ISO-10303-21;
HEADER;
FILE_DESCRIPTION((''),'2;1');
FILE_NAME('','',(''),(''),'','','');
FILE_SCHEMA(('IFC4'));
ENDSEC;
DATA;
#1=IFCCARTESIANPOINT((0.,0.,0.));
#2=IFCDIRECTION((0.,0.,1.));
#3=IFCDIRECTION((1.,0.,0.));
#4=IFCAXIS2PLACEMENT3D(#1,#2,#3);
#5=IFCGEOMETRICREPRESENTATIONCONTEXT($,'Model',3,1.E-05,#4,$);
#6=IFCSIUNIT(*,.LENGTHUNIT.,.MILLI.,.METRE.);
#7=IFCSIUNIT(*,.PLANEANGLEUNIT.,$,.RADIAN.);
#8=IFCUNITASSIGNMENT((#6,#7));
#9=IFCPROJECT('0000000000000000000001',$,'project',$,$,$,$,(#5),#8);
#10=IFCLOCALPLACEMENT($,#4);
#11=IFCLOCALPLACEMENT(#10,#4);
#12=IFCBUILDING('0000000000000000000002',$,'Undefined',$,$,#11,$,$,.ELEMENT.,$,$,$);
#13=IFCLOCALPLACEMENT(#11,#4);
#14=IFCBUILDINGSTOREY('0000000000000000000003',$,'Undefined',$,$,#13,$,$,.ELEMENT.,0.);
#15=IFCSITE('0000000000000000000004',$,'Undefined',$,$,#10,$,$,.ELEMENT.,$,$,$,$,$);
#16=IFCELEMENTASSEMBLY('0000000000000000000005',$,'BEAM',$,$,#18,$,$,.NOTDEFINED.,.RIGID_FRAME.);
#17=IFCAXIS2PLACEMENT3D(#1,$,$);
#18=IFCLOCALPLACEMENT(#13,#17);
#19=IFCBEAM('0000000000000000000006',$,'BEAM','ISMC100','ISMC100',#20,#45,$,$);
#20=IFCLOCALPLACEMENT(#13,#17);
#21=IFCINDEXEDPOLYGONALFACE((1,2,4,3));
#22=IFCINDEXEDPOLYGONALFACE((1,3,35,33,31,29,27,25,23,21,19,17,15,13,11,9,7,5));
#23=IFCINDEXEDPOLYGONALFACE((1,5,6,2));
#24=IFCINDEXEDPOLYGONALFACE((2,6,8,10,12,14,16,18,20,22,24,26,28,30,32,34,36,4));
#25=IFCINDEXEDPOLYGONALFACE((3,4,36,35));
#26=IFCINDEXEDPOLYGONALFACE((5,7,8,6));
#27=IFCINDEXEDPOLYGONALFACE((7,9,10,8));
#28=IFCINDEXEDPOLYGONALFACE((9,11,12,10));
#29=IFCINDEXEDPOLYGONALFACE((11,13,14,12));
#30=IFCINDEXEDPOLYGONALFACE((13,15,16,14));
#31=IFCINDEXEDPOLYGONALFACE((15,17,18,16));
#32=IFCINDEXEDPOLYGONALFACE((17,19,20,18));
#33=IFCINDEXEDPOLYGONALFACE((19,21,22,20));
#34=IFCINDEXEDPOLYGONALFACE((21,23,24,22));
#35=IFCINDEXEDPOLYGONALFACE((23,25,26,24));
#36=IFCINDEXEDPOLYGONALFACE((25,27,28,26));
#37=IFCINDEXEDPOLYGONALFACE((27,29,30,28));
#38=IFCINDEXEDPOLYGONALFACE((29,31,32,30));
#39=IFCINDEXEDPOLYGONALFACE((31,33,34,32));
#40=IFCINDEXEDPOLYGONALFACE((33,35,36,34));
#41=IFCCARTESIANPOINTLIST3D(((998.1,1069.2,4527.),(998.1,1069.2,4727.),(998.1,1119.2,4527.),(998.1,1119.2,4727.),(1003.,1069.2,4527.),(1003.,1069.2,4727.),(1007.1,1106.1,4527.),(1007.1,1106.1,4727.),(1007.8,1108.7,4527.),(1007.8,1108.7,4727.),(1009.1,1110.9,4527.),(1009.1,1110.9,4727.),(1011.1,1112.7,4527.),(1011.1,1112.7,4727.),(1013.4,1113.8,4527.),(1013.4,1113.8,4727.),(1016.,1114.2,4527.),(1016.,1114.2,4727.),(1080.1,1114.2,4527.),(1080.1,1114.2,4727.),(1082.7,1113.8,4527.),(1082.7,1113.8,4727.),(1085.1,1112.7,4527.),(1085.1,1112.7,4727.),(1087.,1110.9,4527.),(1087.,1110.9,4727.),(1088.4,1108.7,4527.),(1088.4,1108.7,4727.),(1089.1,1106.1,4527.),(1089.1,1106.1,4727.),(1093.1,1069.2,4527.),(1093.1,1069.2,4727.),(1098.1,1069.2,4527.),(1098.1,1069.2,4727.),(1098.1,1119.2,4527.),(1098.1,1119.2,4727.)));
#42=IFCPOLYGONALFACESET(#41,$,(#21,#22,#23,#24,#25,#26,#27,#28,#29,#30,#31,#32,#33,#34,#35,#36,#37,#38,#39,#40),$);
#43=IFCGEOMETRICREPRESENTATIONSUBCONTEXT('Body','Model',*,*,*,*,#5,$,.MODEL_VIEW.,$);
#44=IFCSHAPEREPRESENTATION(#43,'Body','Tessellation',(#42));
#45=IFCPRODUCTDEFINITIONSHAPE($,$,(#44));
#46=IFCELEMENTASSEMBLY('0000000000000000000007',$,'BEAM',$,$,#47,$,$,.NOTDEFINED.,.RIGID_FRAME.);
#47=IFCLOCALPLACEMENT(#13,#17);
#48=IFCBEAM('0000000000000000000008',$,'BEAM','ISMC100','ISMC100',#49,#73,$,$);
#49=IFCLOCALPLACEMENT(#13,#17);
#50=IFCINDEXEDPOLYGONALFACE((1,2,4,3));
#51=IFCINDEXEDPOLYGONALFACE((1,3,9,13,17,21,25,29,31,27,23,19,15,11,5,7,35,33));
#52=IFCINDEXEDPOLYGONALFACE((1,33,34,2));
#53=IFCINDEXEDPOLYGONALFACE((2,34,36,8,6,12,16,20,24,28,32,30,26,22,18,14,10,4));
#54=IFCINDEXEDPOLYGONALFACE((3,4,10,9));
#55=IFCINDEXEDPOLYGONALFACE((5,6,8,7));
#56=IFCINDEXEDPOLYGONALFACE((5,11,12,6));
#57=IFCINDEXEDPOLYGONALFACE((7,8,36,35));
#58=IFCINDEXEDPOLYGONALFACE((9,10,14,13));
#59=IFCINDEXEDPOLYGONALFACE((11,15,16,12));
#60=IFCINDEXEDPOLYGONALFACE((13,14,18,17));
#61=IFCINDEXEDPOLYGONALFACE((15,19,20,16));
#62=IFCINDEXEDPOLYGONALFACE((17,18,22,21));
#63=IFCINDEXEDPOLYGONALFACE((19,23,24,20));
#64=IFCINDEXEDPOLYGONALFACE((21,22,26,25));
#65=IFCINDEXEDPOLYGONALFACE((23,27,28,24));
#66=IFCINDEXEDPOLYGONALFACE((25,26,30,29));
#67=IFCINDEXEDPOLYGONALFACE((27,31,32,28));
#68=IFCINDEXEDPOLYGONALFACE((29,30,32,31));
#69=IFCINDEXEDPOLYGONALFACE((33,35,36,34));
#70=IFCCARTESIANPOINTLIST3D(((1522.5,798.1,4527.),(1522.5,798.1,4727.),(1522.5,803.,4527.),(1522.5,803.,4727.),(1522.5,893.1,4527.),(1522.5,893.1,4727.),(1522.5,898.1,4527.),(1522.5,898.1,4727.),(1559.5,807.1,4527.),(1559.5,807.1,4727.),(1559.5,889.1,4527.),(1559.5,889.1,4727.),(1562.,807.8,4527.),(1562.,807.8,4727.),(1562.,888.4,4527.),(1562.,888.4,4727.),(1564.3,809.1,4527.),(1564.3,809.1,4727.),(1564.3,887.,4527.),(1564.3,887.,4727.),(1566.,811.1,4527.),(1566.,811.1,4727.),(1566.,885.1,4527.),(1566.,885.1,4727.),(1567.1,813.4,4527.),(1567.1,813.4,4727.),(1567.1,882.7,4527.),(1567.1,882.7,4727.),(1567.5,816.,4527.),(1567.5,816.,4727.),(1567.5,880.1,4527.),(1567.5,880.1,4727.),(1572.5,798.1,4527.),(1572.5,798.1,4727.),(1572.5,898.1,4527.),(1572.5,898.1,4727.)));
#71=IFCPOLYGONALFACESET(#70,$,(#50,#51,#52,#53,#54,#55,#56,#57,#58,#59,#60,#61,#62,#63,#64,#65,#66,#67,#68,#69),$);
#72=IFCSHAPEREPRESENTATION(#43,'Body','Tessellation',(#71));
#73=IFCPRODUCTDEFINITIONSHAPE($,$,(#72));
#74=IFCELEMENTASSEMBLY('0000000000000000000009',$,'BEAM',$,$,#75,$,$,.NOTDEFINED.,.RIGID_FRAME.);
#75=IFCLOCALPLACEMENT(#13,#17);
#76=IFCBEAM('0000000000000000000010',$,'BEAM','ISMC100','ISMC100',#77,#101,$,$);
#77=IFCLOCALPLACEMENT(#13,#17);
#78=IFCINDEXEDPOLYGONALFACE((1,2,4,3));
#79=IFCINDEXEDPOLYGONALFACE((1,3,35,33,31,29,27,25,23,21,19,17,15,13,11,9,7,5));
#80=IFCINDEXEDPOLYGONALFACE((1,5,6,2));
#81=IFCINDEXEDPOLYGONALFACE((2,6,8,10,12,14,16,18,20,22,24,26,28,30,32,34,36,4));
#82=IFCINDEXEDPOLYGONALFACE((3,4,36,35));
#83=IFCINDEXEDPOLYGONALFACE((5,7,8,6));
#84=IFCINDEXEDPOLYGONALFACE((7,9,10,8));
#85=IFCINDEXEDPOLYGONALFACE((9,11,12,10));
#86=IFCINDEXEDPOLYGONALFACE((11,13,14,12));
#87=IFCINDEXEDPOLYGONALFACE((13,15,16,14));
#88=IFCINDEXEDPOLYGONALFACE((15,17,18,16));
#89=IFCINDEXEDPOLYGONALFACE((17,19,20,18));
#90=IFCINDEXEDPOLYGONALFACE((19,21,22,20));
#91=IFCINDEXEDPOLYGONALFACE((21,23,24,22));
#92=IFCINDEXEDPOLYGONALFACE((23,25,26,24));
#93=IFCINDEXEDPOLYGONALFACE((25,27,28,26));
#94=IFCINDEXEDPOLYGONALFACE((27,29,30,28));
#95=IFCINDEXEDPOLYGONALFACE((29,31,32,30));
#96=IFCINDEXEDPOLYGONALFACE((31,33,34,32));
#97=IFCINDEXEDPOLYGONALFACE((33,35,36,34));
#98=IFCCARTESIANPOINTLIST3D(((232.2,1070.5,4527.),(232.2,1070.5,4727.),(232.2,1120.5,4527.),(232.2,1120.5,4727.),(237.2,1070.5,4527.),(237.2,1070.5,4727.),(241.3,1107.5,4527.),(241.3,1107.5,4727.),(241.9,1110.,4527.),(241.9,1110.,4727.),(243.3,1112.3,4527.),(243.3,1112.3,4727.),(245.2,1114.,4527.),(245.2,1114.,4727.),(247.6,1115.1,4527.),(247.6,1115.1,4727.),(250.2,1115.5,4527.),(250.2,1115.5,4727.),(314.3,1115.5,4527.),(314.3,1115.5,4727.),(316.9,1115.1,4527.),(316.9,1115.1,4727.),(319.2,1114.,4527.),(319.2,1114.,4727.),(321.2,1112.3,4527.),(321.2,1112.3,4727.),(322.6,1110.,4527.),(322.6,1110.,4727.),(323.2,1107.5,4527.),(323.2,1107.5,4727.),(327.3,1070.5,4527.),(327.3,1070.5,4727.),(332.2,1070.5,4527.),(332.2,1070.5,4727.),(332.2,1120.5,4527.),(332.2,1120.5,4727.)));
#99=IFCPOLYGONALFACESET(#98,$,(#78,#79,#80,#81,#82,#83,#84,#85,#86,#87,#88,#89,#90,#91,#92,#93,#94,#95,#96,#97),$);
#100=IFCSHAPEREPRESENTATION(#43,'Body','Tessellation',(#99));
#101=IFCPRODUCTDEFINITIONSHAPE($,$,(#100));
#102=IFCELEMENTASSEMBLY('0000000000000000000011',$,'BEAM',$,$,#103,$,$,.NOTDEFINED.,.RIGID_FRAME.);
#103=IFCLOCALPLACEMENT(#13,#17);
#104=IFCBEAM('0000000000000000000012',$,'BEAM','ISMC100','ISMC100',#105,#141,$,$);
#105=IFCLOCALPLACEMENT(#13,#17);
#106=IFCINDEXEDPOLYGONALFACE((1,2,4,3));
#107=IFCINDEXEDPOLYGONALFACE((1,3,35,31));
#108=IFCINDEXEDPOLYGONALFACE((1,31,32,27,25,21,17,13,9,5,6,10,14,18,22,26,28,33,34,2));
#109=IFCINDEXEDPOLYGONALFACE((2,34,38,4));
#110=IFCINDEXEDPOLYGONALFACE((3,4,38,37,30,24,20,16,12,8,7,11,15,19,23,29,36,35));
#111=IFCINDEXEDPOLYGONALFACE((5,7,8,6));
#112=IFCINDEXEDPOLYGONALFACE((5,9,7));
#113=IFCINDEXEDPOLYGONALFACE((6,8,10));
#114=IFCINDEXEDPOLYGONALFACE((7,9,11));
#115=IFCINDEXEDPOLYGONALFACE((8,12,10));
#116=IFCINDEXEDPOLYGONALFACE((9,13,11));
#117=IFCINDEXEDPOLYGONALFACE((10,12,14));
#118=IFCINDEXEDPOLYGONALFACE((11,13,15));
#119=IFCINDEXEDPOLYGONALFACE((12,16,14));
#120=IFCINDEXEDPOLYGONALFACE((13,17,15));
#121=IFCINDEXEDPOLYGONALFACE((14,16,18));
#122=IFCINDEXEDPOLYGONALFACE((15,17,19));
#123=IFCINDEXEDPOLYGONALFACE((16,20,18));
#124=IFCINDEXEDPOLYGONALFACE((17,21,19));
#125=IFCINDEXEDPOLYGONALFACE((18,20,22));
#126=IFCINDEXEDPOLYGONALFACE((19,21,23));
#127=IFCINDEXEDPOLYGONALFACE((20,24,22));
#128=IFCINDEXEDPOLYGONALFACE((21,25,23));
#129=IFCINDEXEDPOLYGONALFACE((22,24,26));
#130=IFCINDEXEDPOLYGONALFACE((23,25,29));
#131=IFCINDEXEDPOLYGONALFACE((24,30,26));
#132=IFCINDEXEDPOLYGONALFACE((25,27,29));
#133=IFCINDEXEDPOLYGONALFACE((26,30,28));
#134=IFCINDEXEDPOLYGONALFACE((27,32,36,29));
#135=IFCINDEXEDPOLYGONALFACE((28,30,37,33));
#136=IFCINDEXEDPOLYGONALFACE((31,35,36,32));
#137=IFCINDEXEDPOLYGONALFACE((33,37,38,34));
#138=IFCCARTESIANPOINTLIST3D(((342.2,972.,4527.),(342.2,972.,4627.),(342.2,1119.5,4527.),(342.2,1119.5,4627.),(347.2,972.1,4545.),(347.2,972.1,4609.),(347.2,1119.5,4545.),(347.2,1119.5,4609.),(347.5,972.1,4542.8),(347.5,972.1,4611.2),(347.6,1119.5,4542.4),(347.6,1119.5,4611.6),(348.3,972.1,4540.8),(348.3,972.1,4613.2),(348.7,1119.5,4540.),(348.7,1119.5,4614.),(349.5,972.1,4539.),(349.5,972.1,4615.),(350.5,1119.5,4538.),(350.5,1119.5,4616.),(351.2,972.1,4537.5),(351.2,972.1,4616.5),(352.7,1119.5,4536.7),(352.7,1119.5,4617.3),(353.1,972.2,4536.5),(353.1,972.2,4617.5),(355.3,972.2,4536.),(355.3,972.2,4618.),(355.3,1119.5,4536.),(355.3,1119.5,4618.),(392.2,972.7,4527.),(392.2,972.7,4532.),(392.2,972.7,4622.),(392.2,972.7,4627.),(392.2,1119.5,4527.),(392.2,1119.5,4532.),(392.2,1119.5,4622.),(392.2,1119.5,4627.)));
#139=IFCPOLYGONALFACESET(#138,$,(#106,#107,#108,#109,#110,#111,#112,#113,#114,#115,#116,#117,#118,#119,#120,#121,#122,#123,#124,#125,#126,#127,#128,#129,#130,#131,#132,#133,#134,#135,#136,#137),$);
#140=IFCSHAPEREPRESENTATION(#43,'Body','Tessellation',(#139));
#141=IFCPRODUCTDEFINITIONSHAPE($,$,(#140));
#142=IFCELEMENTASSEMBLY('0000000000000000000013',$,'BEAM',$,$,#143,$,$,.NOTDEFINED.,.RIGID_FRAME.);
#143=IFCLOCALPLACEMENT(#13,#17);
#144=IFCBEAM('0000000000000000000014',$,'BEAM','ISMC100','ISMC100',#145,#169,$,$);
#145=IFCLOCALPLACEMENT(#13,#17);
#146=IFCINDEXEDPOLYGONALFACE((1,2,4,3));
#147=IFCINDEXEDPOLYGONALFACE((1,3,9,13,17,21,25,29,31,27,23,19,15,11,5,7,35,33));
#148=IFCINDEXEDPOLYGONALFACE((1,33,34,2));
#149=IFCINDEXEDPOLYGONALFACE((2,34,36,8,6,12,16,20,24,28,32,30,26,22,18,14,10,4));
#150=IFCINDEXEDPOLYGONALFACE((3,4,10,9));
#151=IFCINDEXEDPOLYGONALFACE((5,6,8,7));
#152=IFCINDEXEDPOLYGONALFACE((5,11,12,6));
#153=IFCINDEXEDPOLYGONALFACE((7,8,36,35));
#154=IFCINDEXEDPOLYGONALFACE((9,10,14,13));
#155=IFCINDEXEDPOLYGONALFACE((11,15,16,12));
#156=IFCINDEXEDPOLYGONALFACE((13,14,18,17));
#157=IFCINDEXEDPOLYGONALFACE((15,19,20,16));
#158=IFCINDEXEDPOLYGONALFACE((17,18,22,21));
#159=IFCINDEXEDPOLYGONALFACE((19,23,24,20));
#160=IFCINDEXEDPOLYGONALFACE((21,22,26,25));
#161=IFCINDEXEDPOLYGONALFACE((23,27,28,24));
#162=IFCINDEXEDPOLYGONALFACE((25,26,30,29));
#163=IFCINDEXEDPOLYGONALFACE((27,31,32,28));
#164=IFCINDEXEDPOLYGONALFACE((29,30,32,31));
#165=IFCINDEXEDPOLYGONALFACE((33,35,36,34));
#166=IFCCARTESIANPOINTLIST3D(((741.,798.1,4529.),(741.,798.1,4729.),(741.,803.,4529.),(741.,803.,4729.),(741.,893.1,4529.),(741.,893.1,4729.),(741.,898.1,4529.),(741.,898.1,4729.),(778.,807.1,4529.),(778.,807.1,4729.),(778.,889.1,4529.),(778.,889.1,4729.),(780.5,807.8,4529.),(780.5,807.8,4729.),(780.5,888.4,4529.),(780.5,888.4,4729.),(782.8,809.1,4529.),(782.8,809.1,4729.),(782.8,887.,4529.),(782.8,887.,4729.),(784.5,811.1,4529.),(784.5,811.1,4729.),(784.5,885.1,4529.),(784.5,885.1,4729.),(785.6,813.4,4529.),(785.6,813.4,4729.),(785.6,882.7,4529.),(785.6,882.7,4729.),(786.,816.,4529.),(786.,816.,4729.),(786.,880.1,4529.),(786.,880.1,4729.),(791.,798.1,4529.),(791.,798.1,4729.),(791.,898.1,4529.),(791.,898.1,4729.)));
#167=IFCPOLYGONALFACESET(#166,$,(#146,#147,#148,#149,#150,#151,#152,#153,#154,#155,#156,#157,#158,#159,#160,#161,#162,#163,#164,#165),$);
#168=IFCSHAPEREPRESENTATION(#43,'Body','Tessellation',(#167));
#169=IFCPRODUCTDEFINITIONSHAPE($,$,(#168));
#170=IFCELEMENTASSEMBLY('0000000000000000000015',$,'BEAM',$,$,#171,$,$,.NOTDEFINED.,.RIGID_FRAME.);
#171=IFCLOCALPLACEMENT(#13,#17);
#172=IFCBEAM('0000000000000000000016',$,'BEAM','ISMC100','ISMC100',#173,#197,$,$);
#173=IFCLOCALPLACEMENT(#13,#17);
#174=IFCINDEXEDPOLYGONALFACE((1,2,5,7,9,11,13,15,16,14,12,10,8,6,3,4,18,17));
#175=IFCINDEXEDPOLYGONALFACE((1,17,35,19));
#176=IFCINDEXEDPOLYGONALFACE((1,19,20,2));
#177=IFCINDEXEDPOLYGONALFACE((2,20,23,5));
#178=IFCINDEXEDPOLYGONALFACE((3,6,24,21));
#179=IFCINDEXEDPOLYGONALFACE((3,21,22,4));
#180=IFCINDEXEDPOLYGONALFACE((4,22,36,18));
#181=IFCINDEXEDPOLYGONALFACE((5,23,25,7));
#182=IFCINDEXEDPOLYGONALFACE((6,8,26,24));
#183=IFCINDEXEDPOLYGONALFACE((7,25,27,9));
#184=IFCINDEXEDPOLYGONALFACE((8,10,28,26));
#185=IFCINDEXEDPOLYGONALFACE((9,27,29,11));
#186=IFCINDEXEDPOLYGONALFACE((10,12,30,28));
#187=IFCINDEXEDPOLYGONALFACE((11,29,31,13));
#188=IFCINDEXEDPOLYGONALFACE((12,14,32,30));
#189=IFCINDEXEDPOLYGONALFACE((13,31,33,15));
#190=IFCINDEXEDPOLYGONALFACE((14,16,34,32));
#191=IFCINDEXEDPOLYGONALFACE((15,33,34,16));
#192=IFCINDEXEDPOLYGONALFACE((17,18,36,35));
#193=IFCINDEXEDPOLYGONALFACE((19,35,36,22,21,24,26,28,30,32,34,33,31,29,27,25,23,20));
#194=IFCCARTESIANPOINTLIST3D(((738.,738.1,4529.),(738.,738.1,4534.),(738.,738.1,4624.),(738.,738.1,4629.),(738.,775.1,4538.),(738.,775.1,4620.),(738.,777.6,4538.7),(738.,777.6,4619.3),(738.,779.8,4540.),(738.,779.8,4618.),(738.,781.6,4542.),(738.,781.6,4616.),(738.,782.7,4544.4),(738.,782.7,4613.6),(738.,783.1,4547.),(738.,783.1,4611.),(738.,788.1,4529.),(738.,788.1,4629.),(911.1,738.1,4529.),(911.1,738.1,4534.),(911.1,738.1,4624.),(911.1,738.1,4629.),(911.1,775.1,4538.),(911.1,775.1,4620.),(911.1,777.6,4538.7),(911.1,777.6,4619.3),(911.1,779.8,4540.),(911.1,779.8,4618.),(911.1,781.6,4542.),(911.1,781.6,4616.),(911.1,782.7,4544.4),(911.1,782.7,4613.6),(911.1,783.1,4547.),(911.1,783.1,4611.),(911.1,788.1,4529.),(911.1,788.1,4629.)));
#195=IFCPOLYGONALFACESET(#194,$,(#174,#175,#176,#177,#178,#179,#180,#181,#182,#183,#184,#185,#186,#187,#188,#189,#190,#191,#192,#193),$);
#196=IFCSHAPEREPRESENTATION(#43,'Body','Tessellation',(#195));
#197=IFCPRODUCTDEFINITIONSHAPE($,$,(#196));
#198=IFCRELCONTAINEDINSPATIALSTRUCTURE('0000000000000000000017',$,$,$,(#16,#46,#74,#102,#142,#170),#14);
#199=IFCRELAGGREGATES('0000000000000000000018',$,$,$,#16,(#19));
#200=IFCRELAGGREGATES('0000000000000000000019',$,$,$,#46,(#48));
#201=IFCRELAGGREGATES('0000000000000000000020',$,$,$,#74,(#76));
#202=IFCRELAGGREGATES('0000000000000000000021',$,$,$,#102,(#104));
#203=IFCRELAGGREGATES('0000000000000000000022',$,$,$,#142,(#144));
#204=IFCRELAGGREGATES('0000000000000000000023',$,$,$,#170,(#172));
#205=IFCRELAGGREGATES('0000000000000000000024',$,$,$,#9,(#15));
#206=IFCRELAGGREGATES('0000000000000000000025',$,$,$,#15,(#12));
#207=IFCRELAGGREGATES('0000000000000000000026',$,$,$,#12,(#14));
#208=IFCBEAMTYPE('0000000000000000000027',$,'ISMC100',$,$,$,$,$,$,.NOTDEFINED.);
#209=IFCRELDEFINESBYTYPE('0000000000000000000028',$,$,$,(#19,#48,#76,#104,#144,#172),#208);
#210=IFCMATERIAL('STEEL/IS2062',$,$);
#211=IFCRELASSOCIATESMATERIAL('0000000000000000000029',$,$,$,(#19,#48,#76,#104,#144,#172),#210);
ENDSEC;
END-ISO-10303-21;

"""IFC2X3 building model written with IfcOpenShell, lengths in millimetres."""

from ifc_helpers import new_model, si_unit, frame, origin_with_axes, origin_2d_with_axis, place, context, subcontext, project, spatial, u_section, extrude, clip, halfspace, material, type_object, element, aggregate, save


model = new_model("IFC2X3")

# Units and contexts
model_context = context("Model", 3, precision=1e-05, world=origin_with_axes())
body_context = subcontext(model_context, "Body", "Model", "MODEL_VIEW")
ifc_project = project(units=[si_unit("LENGTHUNIT", "METRE", prefix="MILLI"), si_unit("PLANEANGLEUNIT", "RADIAN")], contexts=[model_context])

# Site, building, storey
site_placement = place(None, origin_with_axes())
site = spatial("IfcSite", under=ifc_project, at=site_placement, Name="Undefined", CompositionType="ELEMENT")
building_placement = place(site_placement, origin_with_axes())
building = spatial("IfcBuilding", under=site, at=building_placement, Name="Undefined", CompositionType="ELEMENT")
storey_placement = place(building_placement, origin_with_axes())
storey = spatial("IfcBuildingStorey", under=building, at=storey_placement, Name="Undefined", CompositionType="ELEMENT", Elevation=0.0)

# Shared definitions
ifc_material = material(Name="STEEL/IS2062")

# Element assemblies, beams
beam_type_1 = type_object("IfcBeamType", Name="ISMC100", PredefinedType="NOTDEFINED")
assembly_1_placement = place(storey_placement, origin_with_axes())
assembly_1 = element("IfcElementAssembly", 1, at=assembly_1_placement, inside=storey, Name="BEAM", AssemblyPlace="NOTDEFINED", PredefinedType="RIGID_FRAME")
beam_1_placement = place(assembly_1_placement, frame((1048.1, 1094.2, 4727.0), z_axis=(1.0, 0.0, 0.0), x_axis=(0.0, 0.0, -1.0)))
beam_1 = element("IfcBeam", 2, at=beam_1_placement, type_object=beam_type_1, material=ifc_material, Name="BEAM", Description="ISMC100", ObjectType="ISMC100", context=body_context, shape_type="SweptSolid", body=[
    extrude(u_section(Depth=100.0, FlangeWidth=50.0, WebThickness=5.0, FlangeThickness=7.7, FilletRadius=9.0, FlangeSlope=0.10956, at=origin_2d_with_axis()), frame((200.0, 0.0, 0.0), z_axis=(-1.0, 0.0, 0.0), x_axis=(0.0, -1.0, 0.0)), (0.0, 0.0, 1.0), 200.0),
])
aggregate(assembly_1, [beam_1])
assembly_2_placement = place(storey_placement, origin_with_axes())
assembly_2 = element("IfcElementAssembly", 3, at=assembly_2_placement, inside=storey, Name="BEAM", AssemblyPlace="NOTDEFINED", PredefinedType="RIGID_FRAME")
beam_2_placement = place(assembly_2_placement, frame((1547.5, 848.1, 4727.0), z_axis=(0.0, -1.0, 0.0), x_axis=(0.0, 0.0, -1.0)))
beam_2 = element("IfcBeam", 4, at=beam_2_placement, type_object=beam_type_1, material=ifc_material, Name="BEAM", Description="ISMC100", ObjectType="ISMC100", context=body_context, shape_type="SweptSolid", body=[
    extrude(u_section(Depth=100.0, FlangeWidth=50.0, WebThickness=5.0, FlangeThickness=7.7, FilletRadius=9.0, FlangeSlope=0.10956, at=origin_2d_with_axis()), frame((200.0, 0.0, 0.0), z_axis=(-1.0, 0.0, 0.0), x_axis=(0.0, -1.0, 0.0)), (0.0, 0.0, 1.0), 200.0),
])
aggregate(assembly_2, [beam_2])
assembly_3_placement = place(storey_placement, origin_with_axes())
assembly_3 = element("IfcElementAssembly", 5, at=assembly_3_placement, inside=storey, Name="BEAM", AssemblyPlace="NOTDEFINED", PredefinedType="RIGID_FRAME")
beam_3_placement = place(assembly_3_placement, frame((282.2, 1095.5, 4727.0), z_axis=(1.0, 0.0, 0.0), x_axis=(0.0, 0.0, -1.0)))
beam_3 = element("IfcBeam", 6, at=beam_3_placement, type_object=beam_type_1, material=ifc_material, Name="BEAM", Description="ISMC100", ObjectType="ISMC100", context=body_context, shape_type="SweptSolid", body=[
    extrude(u_section(Depth=100.0, FlangeWidth=50.0, WebThickness=5.0, FlangeThickness=7.7, FilletRadius=9.0, FlangeSlope=0.10956, at=origin_2d_with_axis()), frame((200.0, 0.0, 0.0), z_axis=(-1.0, 0.0, 0.0), x_axis=(0.0, -1.0, 0.0)), (0.0, 0.0, 1.0), 200.0),
])
aggregate(assembly_3, [beam_3])
assembly_4_placement = place(storey_placement, origin_with_axes())
assembly_4 = element("IfcElementAssembly", 7, at=assembly_4_placement, inside=storey, Name="BEAM", AssemblyPlace="NOTDEFINED", PredefinedType="RIGID_FRAME")
beam_4_placement = place(assembly_4_placement, frame((367.2, 1119.5, 4577.0), z_axis=(0.0, 0.0, -1.0), x_axis=(0.0, -1.0, 0.0)))
beam_4 = element("IfcBeam", 8, at=beam_4_placement, type_object=beam_type_1, material=ifc_material, Name="BEAM", Description="ISMC100", ObjectType="ISMC100", context=body_context, shape_type="Clipping", body=[
    clip(extrude(u_section(Depth=100.0, FlangeWidth=50.0, WebThickness=5.0, FlangeThickness=7.7, FilletRadius=9.0, FlangeSlope=0.10956, at=origin_2d_with_axis()), frame((147.5, 0.0, 0.0), z_axis=(-1.0, 0.0, 0.0), x_axis=(0.0, -1.0, 0.0)), (0.0, 0.0, 1.0), 147.5), halfspace(frame((147.5, 25.0, -50.0), z_axis=(0.999902, -0.013997, 0.0), x_axis=(-0.013997, -0.999902, 0.0)), False)),
])
aggregate(assembly_4, [beam_4])
assembly_5_placement = place(storey_placement, origin_with_axes())
assembly_5 = element("IfcElementAssembly", 9, at=assembly_5_placement, inside=storey, Name="BEAM", AssemblyPlace="NOTDEFINED", PredefinedType="RIGID_FRAME")
beam_5_placement = place(assembly_5_placement, frame((766.0, 848.1, 4729.0), z_axis=(0.0, -1.0, 0.0), x_axis=(0.0, 0.0, -1.0)))
beam_5 = element("IfcBeam", 10, at=beam_5_placement, type_object=beam_type_1, material=ifc_material, Name="BEAM", Description="ISMC100", ObjectType="ISMC100", context=body_context, shape_type="SweptSolid", body=[
    extrude(u_section(Depth=100.0, FlangeWidth=50.0, WebThickness=5.0, FlangeThickness=7.7, FilletRadius=9.0, FlangeSlope=0.10956, at=origin_2d_with_axis()), frame((200.0, 0.0, 0.0), z_axis=(-1.0, 0.0, 0.0), x_axis=(0.0, -1.0, 0.0)), (0.0, 0.0, 1.0), 200.0),
])
aggregate(assembly_5, [beam_5])
assembly_6_placement = place(storey_placement, origin_with_axes())
assembly_6 = element("IfcElementAssembly", 11, at=assembly_6_placement, inside=storey, Name="BEAM", AssemblyPlace="NOTDEFINED", PredefinedType="RIGID_FRAME")
beam_6_placement = place(assembly_6_placement, frame((911.1, 763.1, 4579.0), z_axis=(0.0, 0.0, -1.0), x_axis=(-1.0, 0.0, 0.0)))
beam_6 = element("IfcBeam", 12, at=beam_6_placement, type_object=beam_type_1, material=ifc_material, Name="BEAM", Description="ISMC100", ObjectType="ISMC100", context=body_context, shape_type="SweptSolid", body=[
    extrude(u_section(Depth=100.0, FlangeWidth=50.0, WebThickness=5.0, FlangeThickness=7.7, FilletRadius=9.0, FlangeSlope=0.10956, at=origin_2d_with_axis()), frame((173.1, 0.0, 0.0), z_axis=(-1.0, 0.0, 0.0), x_axis=(0.0, -1.0, 0.0)), (0.0, 0.0, 1.0), 173.1),
])
aggregate(assembly_6, [beam_6])

save(model, "model.ifc")
